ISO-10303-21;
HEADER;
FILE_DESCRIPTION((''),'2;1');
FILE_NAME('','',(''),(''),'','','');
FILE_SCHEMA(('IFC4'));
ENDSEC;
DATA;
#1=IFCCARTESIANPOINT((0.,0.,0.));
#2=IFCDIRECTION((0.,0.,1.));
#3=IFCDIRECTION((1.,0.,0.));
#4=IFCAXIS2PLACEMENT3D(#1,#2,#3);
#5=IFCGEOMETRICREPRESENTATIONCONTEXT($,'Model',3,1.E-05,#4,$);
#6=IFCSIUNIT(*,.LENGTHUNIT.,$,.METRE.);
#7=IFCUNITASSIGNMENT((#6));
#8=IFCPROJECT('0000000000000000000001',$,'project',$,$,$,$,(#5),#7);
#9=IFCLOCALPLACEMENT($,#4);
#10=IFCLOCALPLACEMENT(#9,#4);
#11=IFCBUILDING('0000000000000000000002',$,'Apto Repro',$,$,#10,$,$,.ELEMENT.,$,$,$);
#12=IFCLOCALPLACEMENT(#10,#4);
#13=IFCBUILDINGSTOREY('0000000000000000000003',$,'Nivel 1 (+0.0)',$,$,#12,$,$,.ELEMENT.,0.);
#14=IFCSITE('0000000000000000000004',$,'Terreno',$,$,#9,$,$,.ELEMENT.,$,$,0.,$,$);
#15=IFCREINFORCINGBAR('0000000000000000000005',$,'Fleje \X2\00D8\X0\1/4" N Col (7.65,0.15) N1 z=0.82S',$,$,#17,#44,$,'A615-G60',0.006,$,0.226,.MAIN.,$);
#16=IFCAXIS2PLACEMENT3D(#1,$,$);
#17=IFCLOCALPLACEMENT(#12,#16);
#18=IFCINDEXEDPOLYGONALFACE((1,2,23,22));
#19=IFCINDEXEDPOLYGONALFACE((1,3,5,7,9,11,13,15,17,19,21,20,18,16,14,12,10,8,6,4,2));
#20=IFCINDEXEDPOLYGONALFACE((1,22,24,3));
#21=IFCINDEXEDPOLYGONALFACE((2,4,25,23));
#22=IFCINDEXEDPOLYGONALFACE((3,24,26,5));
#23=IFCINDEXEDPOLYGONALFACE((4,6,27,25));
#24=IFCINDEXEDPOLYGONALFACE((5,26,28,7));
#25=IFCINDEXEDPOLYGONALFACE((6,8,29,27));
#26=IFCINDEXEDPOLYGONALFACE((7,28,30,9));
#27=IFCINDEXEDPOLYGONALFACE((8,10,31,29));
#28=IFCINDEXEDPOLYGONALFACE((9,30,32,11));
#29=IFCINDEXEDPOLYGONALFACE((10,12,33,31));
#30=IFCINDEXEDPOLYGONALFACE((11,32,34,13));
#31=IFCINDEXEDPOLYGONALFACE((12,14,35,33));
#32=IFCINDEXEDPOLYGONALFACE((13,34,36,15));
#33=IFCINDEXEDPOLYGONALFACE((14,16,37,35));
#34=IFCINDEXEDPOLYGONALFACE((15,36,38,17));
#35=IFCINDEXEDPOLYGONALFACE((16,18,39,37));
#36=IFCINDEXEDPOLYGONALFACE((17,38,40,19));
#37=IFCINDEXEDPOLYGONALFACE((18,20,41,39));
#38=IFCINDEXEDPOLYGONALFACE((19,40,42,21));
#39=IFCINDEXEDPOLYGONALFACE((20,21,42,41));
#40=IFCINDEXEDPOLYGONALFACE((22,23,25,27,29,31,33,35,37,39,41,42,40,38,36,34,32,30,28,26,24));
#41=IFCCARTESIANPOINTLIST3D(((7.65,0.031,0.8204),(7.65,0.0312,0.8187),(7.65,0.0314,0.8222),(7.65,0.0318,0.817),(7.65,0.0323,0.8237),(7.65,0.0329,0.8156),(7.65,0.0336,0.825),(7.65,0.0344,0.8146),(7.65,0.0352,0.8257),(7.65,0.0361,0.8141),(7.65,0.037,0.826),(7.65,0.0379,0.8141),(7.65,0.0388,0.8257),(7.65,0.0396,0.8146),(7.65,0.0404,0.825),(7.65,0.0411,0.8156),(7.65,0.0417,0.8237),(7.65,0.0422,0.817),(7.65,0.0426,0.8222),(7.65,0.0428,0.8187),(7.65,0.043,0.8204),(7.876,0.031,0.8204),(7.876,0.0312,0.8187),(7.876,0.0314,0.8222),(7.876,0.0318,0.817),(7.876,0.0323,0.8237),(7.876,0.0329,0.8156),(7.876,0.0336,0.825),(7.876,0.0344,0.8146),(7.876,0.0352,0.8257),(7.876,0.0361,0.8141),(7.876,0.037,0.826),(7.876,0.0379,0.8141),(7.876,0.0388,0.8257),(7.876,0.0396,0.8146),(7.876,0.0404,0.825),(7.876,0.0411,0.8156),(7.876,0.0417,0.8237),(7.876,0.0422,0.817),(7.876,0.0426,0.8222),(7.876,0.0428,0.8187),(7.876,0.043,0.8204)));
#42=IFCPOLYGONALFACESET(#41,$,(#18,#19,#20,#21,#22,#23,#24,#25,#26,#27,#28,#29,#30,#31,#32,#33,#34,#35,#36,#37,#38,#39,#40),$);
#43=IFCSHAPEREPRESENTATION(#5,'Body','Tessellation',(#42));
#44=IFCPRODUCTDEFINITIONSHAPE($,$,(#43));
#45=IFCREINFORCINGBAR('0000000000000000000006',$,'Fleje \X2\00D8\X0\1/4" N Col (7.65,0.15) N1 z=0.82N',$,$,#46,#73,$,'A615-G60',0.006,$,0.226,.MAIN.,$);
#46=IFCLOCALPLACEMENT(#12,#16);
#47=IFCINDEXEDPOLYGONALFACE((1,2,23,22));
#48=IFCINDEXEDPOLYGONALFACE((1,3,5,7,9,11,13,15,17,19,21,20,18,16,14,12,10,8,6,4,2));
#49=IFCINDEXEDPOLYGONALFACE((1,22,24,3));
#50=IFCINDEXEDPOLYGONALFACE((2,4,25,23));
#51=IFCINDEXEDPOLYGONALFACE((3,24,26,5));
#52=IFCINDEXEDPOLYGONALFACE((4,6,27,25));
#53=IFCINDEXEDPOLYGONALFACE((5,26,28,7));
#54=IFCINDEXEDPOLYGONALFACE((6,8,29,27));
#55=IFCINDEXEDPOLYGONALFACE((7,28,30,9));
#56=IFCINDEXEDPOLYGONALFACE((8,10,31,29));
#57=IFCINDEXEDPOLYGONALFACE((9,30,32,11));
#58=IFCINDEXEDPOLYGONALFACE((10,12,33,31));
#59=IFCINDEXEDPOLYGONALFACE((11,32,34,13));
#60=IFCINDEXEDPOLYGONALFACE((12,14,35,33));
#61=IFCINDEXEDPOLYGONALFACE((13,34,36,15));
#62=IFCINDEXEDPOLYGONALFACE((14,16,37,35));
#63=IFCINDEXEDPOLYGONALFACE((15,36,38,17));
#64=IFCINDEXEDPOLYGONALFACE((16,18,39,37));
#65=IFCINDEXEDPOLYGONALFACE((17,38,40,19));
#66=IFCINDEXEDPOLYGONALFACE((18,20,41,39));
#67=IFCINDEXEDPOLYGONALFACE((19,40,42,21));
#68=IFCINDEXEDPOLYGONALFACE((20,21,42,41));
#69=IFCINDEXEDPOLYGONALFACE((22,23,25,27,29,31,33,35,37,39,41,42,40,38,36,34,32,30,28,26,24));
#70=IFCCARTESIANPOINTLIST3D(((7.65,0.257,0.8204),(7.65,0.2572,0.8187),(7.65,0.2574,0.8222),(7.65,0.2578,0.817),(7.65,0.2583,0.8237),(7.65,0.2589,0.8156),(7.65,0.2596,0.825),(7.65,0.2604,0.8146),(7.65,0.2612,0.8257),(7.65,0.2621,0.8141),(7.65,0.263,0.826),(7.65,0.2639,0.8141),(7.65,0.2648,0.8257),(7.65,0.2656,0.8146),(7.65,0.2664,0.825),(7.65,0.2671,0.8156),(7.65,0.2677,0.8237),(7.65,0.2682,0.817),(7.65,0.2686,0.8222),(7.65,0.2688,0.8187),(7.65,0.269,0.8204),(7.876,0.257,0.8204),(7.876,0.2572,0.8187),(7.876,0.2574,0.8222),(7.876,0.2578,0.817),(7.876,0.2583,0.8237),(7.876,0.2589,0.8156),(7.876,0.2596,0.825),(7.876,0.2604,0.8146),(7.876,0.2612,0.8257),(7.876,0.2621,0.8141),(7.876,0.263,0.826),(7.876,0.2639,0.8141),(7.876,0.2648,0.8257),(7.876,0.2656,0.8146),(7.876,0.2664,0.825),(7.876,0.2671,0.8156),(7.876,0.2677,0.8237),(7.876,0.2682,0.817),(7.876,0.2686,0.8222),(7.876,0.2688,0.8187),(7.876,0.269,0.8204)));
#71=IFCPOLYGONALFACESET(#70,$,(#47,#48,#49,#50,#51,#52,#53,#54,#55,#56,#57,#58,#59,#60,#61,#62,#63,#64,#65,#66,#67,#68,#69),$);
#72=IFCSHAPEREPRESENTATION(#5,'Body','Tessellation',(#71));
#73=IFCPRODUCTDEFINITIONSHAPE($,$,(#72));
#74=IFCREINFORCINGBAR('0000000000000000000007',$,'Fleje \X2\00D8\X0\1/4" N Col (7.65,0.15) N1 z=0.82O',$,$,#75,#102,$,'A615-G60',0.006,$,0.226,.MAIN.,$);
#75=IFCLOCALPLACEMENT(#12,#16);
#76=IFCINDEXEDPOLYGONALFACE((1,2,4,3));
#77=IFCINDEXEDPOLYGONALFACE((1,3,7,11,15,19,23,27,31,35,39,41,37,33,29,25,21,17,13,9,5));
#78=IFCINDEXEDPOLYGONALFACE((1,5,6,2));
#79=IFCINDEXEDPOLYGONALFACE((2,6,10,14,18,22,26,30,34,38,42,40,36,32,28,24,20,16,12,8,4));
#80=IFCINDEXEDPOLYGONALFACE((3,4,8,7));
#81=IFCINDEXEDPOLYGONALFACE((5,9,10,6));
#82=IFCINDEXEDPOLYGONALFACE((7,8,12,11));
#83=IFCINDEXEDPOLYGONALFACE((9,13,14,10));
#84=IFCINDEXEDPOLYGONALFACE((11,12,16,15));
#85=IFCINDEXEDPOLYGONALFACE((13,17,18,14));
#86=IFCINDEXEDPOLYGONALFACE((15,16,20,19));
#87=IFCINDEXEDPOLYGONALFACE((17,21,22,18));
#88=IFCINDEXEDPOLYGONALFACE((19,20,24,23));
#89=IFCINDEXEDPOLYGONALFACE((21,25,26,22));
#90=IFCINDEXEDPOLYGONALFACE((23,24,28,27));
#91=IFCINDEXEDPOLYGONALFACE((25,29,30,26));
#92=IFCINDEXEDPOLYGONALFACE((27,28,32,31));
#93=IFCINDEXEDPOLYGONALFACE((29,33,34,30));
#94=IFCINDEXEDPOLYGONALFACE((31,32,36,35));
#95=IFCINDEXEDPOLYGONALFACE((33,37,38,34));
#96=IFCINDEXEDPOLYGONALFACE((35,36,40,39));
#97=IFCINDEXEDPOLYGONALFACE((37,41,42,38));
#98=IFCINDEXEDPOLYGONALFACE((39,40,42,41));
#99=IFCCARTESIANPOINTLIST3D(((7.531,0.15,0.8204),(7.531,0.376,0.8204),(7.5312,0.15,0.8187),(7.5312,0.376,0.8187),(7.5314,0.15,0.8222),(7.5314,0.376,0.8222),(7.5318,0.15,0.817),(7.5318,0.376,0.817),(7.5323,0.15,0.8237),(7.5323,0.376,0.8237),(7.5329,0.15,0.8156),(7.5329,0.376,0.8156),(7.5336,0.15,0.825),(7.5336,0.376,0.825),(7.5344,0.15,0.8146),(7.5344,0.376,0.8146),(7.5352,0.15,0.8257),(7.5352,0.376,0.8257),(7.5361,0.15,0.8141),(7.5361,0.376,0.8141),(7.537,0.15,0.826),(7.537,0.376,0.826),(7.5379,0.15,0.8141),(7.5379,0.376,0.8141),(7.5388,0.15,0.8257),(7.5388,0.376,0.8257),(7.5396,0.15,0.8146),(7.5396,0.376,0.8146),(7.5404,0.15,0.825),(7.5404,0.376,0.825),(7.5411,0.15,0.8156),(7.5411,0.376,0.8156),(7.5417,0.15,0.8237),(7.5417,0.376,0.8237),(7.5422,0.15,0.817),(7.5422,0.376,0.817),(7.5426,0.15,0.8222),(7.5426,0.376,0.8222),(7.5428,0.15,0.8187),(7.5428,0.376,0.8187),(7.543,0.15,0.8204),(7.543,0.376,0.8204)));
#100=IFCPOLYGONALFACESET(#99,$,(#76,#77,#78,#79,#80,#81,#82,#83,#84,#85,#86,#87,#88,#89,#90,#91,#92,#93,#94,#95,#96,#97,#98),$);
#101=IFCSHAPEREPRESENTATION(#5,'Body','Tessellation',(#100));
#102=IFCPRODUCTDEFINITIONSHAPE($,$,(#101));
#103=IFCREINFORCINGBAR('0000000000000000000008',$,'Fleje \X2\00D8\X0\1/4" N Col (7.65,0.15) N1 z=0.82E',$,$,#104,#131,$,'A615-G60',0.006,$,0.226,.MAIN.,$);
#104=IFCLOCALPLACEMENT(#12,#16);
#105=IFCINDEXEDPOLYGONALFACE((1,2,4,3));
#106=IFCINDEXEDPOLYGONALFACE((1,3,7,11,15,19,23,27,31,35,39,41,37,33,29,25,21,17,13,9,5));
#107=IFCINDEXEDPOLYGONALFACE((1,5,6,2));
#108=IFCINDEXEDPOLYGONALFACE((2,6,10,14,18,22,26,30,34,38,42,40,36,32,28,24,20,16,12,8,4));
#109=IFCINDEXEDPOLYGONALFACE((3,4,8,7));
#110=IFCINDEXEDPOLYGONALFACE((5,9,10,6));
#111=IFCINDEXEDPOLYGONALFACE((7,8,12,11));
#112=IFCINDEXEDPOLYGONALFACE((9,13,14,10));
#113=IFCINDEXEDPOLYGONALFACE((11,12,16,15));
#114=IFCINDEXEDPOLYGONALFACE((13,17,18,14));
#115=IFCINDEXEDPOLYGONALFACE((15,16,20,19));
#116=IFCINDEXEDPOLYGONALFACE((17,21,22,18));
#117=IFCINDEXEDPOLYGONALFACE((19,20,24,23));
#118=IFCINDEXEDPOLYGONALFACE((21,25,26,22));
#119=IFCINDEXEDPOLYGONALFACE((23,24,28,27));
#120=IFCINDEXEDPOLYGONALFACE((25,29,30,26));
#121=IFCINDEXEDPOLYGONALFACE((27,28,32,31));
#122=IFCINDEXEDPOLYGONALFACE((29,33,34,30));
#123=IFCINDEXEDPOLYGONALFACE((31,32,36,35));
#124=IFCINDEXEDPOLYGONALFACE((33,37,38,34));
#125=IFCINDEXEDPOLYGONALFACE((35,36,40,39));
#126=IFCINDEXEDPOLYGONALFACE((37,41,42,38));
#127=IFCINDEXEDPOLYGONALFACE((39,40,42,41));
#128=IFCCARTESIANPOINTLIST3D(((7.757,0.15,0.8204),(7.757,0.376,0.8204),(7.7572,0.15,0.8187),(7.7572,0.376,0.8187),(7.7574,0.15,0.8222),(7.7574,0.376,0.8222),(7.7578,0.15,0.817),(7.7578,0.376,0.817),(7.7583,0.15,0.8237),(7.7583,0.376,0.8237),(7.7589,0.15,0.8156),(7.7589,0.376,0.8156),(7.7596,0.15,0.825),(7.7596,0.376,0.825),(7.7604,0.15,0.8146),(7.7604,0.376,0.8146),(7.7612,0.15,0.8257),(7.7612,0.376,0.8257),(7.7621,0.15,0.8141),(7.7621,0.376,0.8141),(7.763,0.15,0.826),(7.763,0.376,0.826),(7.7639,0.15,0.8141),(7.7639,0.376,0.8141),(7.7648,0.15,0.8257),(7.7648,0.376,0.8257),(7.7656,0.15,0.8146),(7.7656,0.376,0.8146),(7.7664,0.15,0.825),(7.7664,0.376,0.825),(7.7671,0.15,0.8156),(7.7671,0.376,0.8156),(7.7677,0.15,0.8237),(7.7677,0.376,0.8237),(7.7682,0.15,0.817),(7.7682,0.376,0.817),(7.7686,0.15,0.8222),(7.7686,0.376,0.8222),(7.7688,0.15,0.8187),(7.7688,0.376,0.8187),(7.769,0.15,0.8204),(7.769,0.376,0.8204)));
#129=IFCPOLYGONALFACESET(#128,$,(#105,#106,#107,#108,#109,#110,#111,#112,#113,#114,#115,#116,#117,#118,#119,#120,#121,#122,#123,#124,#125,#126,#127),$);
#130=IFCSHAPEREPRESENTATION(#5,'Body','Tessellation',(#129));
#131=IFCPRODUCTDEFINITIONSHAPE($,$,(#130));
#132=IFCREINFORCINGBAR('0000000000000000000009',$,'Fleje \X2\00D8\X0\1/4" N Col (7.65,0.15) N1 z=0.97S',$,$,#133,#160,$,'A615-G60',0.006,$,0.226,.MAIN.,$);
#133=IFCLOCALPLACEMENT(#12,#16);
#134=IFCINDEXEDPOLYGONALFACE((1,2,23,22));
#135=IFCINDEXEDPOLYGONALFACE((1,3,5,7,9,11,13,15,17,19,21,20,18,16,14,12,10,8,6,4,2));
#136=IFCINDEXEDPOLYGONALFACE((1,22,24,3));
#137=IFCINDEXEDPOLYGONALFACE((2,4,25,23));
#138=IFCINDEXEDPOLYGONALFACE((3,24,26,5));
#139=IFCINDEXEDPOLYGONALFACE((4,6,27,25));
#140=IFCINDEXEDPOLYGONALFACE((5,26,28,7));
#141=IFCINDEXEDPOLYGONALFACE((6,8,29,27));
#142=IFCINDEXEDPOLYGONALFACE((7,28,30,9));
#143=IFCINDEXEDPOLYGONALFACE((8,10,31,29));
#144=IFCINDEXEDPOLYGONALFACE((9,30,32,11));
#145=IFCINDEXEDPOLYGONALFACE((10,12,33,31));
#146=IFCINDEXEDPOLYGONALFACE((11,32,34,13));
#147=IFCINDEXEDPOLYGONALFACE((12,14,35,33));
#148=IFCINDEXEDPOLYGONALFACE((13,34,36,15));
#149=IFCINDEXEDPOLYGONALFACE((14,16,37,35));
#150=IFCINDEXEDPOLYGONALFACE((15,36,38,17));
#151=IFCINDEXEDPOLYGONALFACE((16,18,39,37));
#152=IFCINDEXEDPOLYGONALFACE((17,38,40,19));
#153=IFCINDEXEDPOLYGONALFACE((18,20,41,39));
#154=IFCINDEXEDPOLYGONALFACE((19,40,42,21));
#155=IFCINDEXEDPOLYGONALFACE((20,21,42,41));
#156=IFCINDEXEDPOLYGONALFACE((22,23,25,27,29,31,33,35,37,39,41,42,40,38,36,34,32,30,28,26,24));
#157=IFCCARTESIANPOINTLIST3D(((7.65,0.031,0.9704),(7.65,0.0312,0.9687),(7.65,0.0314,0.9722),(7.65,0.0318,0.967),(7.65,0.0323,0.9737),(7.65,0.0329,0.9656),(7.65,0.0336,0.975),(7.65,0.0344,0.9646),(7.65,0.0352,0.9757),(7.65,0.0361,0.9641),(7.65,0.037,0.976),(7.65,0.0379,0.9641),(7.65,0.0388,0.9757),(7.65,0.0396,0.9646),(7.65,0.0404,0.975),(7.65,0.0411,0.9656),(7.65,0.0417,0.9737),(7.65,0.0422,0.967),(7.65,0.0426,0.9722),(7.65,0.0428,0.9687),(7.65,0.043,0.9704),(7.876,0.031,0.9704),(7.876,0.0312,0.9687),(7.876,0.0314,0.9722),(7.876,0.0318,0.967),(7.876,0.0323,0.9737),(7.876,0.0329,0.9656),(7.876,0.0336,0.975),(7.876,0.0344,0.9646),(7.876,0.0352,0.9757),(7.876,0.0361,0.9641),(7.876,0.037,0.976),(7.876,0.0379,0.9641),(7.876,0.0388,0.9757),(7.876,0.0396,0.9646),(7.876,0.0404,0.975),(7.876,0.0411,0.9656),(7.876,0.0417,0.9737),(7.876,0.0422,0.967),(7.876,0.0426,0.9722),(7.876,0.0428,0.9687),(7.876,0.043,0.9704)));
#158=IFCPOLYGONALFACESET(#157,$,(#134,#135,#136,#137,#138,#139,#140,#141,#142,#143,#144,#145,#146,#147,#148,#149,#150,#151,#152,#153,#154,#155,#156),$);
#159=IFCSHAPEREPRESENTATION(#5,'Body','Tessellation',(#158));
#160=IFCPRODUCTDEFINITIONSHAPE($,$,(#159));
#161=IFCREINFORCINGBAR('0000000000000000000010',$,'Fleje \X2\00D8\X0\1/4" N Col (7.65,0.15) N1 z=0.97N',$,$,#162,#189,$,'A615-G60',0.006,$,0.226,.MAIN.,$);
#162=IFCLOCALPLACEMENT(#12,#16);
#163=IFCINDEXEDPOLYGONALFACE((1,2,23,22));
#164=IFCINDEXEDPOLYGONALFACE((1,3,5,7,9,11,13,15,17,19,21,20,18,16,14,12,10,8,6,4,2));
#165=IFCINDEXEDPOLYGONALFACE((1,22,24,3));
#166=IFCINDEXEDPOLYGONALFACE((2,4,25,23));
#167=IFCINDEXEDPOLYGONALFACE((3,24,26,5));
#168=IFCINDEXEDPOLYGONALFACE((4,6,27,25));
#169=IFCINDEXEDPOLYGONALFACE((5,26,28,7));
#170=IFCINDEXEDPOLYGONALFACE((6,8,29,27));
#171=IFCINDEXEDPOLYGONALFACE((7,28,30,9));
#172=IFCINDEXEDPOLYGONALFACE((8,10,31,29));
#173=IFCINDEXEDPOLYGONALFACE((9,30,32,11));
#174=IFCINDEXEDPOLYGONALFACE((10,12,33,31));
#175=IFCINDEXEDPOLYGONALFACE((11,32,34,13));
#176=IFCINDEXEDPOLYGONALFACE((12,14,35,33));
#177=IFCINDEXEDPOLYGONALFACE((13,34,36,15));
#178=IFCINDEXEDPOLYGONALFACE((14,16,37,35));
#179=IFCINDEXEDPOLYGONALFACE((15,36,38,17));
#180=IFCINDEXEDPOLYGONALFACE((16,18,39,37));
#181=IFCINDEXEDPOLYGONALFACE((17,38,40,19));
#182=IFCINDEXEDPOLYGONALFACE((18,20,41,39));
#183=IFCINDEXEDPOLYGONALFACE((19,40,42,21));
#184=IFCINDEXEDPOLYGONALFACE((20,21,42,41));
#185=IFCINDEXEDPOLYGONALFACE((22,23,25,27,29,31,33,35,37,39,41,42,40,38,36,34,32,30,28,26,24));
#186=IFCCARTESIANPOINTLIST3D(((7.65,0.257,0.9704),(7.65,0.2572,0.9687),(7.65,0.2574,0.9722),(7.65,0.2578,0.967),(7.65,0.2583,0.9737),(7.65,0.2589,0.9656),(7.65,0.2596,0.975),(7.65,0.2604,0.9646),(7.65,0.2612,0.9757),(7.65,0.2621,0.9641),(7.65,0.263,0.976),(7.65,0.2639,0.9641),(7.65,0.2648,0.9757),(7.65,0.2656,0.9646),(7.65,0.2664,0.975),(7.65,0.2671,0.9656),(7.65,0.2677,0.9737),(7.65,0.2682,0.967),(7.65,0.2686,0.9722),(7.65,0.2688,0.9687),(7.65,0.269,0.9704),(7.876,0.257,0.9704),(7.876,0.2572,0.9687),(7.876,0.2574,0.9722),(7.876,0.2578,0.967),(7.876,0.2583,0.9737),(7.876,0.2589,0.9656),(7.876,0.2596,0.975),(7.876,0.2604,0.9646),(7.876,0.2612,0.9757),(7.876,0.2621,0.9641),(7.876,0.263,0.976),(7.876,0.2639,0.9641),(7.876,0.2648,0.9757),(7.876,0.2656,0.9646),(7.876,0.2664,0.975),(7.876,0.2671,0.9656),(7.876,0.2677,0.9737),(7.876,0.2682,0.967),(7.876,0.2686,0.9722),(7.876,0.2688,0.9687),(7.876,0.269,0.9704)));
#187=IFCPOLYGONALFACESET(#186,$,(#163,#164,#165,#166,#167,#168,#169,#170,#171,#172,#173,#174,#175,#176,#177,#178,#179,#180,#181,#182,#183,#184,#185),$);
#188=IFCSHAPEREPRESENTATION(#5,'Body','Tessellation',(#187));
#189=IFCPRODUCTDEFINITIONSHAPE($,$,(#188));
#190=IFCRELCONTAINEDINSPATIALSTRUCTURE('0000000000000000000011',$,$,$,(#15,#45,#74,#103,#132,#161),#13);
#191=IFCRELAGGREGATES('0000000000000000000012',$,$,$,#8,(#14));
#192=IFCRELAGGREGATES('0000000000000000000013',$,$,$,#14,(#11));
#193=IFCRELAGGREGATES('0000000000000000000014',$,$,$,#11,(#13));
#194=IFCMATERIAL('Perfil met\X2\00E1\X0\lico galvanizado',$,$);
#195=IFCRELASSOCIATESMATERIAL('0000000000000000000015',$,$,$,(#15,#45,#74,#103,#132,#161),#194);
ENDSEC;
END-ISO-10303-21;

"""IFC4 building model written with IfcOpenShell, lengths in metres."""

from ifc_helpers import new_model, si_unit, frame, origin_with_axes, origin_2d_with_axis, place, context, project, spatial, circle, extrude, material, element, save


model = new_model("IFC4")

# Units and contexts
model_context = context("Model", 3, precision=1e-05, world=origin_with_axes())
ifc_project = project(units=[si_unit("LENGTHUNIT", "METRE")], contexts=[model_context])

# Site, building, storey
site_placement = place(None, origin_with_axes())
site = spatial("IfcSite", under=ifc_project, at=site_placement, Name="Terreno", CompositionType="ELEMENT", RefElevation=0.0)
building_placement = place(site_placement, origin_with_axes())
building = spatial("IfcBuilding", under=site, at=building_placement, Name="Apto Repro", CompositionType="ELEMENT")
storey_placement = place(building_placement, origin_with_axes())
storey = spatial("IfcBuildingStorey", under=building, at=storey_placement, Name="Nivel 1 (+0.0)", CompositionType="ELEMENT", Elevation=0.0)

# Reinforcing bars
ifc_material = material(Name="Perfil metálico galvanizado")
reinforcing_bar_1_placement = place(storey_placement, origin_with_axes())
element("IfcReinforcingBar", 1, at=reinforcing_bar_1_placement, inside=storey, material=ifc_material, Name="Fleje Ø1/4\" N Col (7.65,0.15) N1 z=0.82S", SteelGrade="A615-G60", BarLength=0.226, NominalDiameter=0.006, PredefinedType="MAIN", context=model_context, shape_type="SweptSolid", body=[
    extrude(circle(Radius=0.006, at=origin_2d_with_axis()), frame((7.65, 0.037, 0.82), z_axis=(1.0, 0.0, 0.0), x_axis=(0.0, 0.0, 1.0)), (0.0, 0.0, 1.0), 0.226),
])
reinforcing_bar_2_placement = place(storey_placement, origin_with_axes())
element("IfcReinforcingBar", 2, at=reinforcing_bar_2_placement, inside=storey, material=ifc_material, Name="Fleje Ø1/4\" N Col (7.65,0.15) N1 z=0.82N", SteelGrade="A615-G60", BarLength=0.226, NominalDiameter=0.006, PredefinedType="MAIN", context=model_context, shape_type="SweptSolid", body=[
    extrude(circle(Radius=0.006, at=origin_2d_with_axis()), frame((7.65, 0.263, 0.82), z_axis=(1.0, 0.0, 0.0), x_axis=(0.0, 0.0, 1.0)), (0.0, 0.0, 1.0), 0.226),
])
reinforcing_bar_3_placement = place(storey_placement, origin_with_axes())
element("IfcReinforcingBar", 3, at=reinforcing_bar_3_placement, inside=storey, material=ifc_material, Name="Fleje Ø1/4\" N Col (7.65,0.15) N1 z=0.82O", SteelGrade="A615-G60", BarLength=0.226, NominalDiameter=0.006, PredefinedType="MAIN", context=model_context, shape_type="SweptSolid", body=[
    extrude(circle(Radius=0.006, at=origin_2d_with_axis()), frame((7.537, 0.15, 0.82), z_axis=(0.0, 1.0, 0.0), x_axis=(0.0, 0.0, 1.0)), (0.0, 0.0, 1.0), 0.226),
])
reinforcing_bar_4_placement = place(storey_placement, origin_with_axes())
element("IfcReinforcingBar", 4, at=reinforcing_bar_4_placement, inside=storey, material=ifc_material, Name="Fleje Ø1/4\" N Col (7.65,0.15) N1 z=0.82E", SteelGrade="A615-G60", BarLength=0.226, NominalDiameter=0.006, PredefinedType="MAIN", context=model_context, shape_type="SweptSolid", body=[
    extrude(circle(Radius=0.006, at=origin_2d_with_axis()), frame((7.763, 0.15, 0.82), z_axis=(0.0, 1.0, 0.0), x_axis=(0.0, 0.0, 1.0)), (0.0, 0.0, 1.0), 0.226),
])
reinforcing_bar_5_placement = place(storey_placement, origin_with_axes())
element("IfcReinforcingBar", 5, at=reinforcing_bar_5_placement, inside=storey, material=ifc_material, Name="Fleje Ø1/4\" N Col (7.65,0.15) N1 z=0.97S", SteelGrade="A615-G60", BarLength=0.226, NominalDiameter=0.006, PredefinedType="MAIN", context=model_context, shape_type="SweptSolid", body=[
    extrude(circle(Radius=0.006, at=origin_2d_with_axis()), frame((7.65, 0.037, 0.97), z_axis=(1.0, 0.0, 0.0), x_axis=(0.0, 0.0, 1.0)), (0.0, 0.0, 1.0), 0.226),
])
reinforcing_bar_6_placement = place(storey_placement, origin_with_axes())
element("IfcReinforcingBar", 6, at=reinforcing_bar_6_placement, inside=storey, material=ifc_material, Name="Fleje Ø1/4\" N Col (7.65,0.15) N1 z=0.97N", SteelGrade="A615-G60", BarLength=0.226, NominalDiameter=0.006, PredefinedType="MAIN", context=model_context, shape_type="SweptSolid", body=[
    extrude(circle(Radius=0.006, at=origin_2d_with_axis()), frame((7.65, 0.263, 0.97), z_axis=(1.0, 0.0, 0.0), x_axis=(0.0, 0.0, 1.0)), (0.0, 0.0, 1.0), 0.226),
])

save(model, "model.ifc")
